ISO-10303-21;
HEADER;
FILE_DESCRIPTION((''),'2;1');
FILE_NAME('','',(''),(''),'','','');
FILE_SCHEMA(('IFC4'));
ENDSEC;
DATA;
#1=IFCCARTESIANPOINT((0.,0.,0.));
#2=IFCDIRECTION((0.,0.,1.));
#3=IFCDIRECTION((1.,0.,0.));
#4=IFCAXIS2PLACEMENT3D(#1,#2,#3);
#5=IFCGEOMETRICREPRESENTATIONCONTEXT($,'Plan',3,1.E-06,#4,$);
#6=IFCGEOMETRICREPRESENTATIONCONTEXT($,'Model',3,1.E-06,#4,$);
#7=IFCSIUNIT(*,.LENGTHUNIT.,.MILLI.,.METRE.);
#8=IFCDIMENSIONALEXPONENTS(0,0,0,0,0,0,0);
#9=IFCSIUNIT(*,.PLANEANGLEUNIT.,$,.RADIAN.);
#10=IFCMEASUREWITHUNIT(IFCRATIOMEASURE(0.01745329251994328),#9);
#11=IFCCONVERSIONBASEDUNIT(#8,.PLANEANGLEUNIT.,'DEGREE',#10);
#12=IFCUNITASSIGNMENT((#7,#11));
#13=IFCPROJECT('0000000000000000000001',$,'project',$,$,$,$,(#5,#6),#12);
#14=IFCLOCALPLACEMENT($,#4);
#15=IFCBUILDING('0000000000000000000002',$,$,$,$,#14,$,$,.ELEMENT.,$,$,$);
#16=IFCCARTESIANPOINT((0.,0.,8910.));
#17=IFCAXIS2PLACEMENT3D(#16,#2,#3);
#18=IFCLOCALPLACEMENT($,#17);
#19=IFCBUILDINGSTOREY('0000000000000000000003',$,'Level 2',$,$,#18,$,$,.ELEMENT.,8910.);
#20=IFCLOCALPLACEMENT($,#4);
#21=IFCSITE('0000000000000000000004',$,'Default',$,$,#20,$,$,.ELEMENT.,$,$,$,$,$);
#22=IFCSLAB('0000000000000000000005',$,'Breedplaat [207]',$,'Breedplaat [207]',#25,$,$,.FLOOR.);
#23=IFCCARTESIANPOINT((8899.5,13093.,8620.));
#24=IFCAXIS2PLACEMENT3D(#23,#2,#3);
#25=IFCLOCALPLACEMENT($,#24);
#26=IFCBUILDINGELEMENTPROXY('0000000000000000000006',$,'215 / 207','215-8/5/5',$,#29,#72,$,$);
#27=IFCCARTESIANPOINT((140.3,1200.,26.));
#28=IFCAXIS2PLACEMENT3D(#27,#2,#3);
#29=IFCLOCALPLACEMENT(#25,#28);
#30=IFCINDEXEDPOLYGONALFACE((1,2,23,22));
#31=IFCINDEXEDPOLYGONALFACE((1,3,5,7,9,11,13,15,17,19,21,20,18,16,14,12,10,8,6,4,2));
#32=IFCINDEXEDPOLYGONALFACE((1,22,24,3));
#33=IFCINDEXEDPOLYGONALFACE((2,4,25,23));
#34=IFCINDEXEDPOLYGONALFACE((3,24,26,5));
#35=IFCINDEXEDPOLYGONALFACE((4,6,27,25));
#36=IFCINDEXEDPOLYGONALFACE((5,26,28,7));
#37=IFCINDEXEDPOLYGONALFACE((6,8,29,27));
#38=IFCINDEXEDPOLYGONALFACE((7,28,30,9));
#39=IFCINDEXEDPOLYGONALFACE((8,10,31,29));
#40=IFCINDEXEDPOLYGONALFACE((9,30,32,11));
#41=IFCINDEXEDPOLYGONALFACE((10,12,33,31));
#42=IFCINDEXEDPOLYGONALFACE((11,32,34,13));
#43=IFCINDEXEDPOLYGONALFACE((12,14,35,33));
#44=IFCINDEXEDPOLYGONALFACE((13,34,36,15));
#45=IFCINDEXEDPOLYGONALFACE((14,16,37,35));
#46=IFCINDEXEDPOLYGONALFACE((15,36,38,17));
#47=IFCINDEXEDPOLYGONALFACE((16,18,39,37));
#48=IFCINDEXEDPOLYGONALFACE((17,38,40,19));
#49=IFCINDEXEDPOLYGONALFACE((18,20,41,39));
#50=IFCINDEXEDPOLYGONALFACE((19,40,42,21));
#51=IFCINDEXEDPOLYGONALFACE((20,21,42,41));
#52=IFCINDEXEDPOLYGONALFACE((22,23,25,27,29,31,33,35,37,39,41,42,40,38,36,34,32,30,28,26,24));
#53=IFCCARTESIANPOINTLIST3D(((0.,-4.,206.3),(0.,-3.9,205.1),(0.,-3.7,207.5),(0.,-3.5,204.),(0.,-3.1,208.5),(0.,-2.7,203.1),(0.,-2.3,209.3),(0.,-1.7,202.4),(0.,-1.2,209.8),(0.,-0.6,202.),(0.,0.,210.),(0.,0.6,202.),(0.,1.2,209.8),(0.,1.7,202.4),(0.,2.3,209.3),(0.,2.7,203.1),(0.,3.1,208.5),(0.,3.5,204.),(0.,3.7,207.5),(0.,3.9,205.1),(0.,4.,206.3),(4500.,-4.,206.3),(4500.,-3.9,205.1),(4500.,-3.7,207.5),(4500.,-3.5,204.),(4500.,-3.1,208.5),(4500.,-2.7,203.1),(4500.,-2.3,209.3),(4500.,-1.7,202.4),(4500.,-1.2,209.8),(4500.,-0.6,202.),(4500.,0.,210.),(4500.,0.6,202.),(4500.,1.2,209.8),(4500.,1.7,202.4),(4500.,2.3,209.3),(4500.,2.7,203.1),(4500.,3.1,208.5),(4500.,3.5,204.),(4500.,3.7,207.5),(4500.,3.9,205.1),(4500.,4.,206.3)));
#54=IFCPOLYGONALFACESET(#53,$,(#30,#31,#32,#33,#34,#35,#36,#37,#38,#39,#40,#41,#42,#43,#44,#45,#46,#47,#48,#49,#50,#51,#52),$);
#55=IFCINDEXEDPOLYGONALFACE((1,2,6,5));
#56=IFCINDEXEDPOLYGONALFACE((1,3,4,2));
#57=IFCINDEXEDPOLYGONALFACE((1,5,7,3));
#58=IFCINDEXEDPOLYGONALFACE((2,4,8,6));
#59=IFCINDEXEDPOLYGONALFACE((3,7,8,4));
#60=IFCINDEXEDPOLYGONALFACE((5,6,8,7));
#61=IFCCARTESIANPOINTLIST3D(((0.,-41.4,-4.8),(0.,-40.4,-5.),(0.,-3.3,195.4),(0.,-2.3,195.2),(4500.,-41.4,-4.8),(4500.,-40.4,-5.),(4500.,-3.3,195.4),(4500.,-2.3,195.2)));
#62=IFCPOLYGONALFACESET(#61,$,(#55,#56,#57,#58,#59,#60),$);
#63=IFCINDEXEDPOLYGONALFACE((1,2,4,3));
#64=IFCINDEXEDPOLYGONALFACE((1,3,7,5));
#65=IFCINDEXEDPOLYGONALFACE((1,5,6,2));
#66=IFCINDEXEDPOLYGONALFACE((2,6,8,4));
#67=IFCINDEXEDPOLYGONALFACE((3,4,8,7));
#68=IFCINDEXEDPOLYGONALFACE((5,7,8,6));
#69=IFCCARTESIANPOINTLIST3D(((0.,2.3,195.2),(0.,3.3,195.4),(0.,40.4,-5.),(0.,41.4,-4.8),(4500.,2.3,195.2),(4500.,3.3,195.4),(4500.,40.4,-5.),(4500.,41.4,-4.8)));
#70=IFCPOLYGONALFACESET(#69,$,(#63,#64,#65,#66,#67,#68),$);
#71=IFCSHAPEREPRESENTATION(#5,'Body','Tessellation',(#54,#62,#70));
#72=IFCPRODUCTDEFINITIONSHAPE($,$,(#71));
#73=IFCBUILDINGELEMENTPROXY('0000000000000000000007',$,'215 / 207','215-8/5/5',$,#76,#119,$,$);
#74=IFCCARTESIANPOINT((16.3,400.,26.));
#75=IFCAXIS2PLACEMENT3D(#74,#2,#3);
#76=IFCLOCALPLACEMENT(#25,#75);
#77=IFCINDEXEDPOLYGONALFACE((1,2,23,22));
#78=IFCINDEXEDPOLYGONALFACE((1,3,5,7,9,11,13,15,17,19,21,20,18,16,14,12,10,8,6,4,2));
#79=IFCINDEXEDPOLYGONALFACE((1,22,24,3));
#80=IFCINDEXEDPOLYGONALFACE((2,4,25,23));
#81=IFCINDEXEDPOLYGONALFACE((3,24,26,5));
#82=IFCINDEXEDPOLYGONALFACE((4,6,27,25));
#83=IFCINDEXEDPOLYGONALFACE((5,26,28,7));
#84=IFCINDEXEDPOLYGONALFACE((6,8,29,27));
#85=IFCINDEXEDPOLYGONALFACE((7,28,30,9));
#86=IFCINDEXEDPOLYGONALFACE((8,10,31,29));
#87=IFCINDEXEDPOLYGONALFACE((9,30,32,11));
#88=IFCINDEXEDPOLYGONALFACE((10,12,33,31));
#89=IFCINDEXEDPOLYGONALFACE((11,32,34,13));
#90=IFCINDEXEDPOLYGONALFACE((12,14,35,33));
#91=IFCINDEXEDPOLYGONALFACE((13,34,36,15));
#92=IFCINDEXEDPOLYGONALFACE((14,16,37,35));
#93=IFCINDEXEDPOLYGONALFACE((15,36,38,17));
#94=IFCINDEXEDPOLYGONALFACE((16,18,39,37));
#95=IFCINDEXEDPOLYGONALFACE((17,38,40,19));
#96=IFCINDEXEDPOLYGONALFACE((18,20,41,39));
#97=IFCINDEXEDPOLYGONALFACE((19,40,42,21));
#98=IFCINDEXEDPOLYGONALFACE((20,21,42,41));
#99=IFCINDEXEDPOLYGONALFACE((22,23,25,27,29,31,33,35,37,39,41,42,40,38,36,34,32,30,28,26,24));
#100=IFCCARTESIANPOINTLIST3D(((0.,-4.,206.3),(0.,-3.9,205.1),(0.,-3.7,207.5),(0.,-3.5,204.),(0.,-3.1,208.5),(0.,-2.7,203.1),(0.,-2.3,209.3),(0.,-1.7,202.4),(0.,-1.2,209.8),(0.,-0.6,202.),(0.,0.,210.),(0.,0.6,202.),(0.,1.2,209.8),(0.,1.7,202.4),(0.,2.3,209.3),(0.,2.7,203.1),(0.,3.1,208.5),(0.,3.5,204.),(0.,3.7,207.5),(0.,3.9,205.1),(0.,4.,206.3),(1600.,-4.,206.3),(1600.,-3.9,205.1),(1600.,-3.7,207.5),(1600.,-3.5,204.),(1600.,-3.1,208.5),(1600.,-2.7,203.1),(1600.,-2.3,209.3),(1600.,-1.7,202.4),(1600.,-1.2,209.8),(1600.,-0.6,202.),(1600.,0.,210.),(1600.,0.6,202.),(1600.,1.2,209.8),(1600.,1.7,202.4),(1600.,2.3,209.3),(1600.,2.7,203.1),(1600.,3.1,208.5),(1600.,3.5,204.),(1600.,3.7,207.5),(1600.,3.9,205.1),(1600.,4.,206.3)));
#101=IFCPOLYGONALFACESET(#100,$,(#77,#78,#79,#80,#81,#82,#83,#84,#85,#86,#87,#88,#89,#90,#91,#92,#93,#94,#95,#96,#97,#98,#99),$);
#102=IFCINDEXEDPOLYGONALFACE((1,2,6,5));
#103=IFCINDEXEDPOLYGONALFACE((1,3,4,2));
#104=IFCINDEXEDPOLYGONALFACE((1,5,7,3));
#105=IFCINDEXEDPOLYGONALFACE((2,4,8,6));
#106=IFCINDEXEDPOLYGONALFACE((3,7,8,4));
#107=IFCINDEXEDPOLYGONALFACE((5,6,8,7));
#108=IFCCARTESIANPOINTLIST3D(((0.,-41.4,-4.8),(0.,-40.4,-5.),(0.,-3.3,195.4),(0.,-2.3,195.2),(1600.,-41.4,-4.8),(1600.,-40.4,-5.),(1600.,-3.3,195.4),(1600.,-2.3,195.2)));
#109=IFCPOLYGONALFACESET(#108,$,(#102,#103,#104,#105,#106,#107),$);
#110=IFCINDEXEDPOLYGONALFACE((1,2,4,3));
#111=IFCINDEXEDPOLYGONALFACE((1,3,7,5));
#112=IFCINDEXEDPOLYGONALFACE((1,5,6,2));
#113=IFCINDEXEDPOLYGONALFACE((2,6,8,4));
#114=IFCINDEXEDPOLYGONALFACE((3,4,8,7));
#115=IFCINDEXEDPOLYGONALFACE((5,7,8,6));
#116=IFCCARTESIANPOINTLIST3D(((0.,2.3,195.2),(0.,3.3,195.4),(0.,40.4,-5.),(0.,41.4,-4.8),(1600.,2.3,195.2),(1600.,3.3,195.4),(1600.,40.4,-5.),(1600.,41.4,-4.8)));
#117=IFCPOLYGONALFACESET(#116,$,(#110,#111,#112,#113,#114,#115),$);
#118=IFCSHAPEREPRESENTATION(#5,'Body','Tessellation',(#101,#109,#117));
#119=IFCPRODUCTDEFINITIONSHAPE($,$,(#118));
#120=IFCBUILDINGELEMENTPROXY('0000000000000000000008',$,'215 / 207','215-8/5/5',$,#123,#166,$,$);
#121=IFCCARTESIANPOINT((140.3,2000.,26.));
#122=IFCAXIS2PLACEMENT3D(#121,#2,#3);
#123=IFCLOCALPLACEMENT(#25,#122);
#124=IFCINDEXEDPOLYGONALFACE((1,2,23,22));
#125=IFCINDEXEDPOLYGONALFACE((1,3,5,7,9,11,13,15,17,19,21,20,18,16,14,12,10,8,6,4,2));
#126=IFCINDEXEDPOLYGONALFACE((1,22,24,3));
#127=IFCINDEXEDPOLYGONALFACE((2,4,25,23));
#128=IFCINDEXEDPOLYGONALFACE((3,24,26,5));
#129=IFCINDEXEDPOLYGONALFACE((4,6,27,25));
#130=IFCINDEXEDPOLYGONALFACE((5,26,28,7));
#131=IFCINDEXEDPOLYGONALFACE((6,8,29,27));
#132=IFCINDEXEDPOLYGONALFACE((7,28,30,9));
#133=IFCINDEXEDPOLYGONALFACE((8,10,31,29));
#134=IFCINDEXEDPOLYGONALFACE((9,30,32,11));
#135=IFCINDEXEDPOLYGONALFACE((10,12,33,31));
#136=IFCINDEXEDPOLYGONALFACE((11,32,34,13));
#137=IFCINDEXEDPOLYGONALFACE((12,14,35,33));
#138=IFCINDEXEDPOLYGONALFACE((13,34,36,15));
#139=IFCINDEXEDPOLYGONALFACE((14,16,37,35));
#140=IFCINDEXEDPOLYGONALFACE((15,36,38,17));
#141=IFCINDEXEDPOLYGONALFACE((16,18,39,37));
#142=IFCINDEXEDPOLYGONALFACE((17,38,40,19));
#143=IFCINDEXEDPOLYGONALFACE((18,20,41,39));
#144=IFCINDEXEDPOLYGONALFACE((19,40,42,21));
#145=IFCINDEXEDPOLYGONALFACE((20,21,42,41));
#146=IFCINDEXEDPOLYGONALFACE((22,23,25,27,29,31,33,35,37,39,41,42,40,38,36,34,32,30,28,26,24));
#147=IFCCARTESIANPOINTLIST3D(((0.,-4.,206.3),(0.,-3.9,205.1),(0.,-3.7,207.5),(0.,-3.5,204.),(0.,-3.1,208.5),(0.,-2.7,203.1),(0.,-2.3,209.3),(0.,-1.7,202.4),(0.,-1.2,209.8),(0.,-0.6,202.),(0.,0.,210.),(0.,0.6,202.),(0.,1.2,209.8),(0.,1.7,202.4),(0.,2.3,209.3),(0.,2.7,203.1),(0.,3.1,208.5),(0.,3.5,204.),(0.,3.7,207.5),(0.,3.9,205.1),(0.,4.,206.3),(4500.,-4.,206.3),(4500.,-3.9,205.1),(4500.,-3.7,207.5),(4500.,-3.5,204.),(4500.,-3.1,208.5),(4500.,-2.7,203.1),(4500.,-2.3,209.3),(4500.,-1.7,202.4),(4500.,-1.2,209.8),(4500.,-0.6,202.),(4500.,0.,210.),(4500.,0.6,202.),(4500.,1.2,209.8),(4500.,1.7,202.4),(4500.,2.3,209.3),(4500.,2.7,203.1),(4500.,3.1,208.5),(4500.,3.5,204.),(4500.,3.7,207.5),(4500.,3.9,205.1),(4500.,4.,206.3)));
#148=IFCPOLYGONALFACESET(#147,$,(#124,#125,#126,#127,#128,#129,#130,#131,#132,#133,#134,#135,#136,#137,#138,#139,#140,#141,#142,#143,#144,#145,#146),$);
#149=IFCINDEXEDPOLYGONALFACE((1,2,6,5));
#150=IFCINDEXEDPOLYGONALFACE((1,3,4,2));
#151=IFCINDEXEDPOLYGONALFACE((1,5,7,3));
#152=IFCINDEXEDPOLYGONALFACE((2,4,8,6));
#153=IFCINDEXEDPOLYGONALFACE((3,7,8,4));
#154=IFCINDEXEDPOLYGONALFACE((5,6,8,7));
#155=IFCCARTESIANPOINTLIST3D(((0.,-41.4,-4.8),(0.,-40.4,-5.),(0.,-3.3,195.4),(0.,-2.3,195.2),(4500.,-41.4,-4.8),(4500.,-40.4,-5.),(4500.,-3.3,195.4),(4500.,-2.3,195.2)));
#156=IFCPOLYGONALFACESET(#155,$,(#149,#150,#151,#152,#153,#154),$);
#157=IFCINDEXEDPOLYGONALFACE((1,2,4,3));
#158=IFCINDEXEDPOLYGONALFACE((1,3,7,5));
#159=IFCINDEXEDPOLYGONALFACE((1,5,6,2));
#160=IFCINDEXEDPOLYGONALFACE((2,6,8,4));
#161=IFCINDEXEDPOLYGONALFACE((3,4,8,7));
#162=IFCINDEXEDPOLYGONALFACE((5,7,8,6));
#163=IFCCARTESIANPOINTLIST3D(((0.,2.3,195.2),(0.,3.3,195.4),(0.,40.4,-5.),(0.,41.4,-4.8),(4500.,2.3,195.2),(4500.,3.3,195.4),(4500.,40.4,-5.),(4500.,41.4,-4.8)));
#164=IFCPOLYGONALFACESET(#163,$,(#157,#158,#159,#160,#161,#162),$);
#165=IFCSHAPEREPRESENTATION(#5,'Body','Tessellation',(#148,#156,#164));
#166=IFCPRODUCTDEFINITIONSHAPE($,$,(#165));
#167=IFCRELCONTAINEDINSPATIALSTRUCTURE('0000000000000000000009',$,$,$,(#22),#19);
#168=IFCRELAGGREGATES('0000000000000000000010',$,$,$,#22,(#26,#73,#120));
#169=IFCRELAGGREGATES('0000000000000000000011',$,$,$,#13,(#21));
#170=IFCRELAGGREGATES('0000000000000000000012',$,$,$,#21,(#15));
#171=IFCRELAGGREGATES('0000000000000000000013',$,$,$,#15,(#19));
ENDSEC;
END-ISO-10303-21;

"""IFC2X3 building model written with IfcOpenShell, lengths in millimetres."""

from ifc_helpers import new_model, entity, si_unit, converted_unit, frame, origin_with_axes, origin_2d_with_axis, place, context, project, spatial, rectangle, circle, extrude, element, aggregate, save


model = new_model("IFC2X3")

# Units and contexts
plan_context = context("Plan", 3, precision=1e-06, world=origin_with_axes())
model_context = context("Model", 3, precision=1e-06, world=origin_with_axes())
ifc_project = project(units=[si_unit("LENGTHUNIT", "METRE", prefix="MILLI"), converted_unit("PLANEANGLEUNIT", "DEGREE", entity("IfcRatioMeasure", 0.01745329251994328), si_unit("PLANEANGLEUNIT", "RADIAN"), dimensions=[0, 0, 0, 0, 0, 0, 0])], contexts=[plan_context, model_context])

# Site, building, storey
site_placement = place(None, origin_with_axes())
site = spatial("IfcSite", under=ifc_project, at=site_placement, Name="Default", CompositionType="ELEMENT")
building_placement = place(None, origin_with_axes())
building = spatial("IfcBuilding", under=site, at=building_placement, CompositionType="ELEMENT")
storey_placement = place(None, frame((0.0, 0.0, 8910.0), z_axis=(0.0, 0.0, 1.0), x_axis=(1.0, 0.0, 0.0)))
storey = spatial("IfcBuildingStorey", under=building, at=storey_placement, Name="Level 2", CompositionType="ELEMENT", Elevation=8910.0)

# Slab, building element proxies
slab_1_placement = place(None, frame((8899.5, 13093.0, 8620.0), z_axis=(0.0, 0.0, 1.0), x_axis=(1.0, 0.0, 0.0)))
slab_1 = element("IfcSlab", 1, at=slab_1_placement, inside=storey, Name="Breedplaat [207]", ObjectType="Breedplaat [207]", PredefinedType="FLOOR")
proxy_1_placement = place(slab_1_placement, frame((140.3, 1200.0, 26.0), z_axis=(0.0, 0.0, 1.0), x_axis=(1.0, 0.0, 0.0)))
proxy_1 = element("IfcBuildingElementProxy", 2, at=proxy_1_placement, Name="215 / 207", Description="215-8/5/5", context=plan_context, shape_type="SweptSolid", body=[
    extrude(circle(Radius=4.0, at=origin_2d_with_axis()), frame((0.0, 0.0, 206.0), z_axis=(1.0, 0.0, 0.0), x_axis=(0.0, 0.0, 1.0)), (0.0, 0.0, 1.0), 4500.0),
    extrude(rectangle(XDim=203.8, YDim=1.0, at=origin_2d_with_axis()), frame((0.0, -21.9, 95.2), z_axis=(1.0, 0.0, 0.0), x_axis=(0.0, 0.187112, 0.982339)), (0.0, 0.0, 1.0), 4500.0),
    extrude(rectangle(XDim=203.8, YDim=1.0, at=origin_2d_with_axis()), frame((0.0, 21.9, 95.2), z_axis=(1.0, 0.0, 0.0), x_axis=(0.0, -0.187112, 0.982339)), (0.0, 0.0, 1.0), 4500.0),
])
proxy_2_placement = place(slab_1_placement, frame((16.3, 400.0, 26.0), z_axis=(0.0, 0.0, 1.0), x_axis=(1.0, 0.0, 0.0)))
proxy_2 = element("IfcBuildingElementProxy", 3, at=proxy_2_placement, Name="215 / 207", Description="215-8/5/5", context=plan_context, shape_type="SweptSolid", body=[
    extrude(circle(Radius=4.0, at=origin_2d_with_axis()), frame((0.0, 0.0, 206.0), z_axis=(1.0, 0.0, 0.0), x_axis=(0.0, 0.0, 1.0)), (0.0, 0.0, 1.0), 1600.0),
    extrude(rectangle(XDim=203.8, YDim=1.0, at=origin_2d_with_axis()), frame((0.0, -21.9, 95.2), z_axis=(1.0, 0.0, 0.0), x_axis=(0.0, 0.187112, 0.982339)), (0.0, 0.0, 1.0), 1600.0),
    extrude(rectangle(XDim=203.8, YDim=1.0, at=origin_2d_with_axis()), frame((0.0, 21.9, 95.2), z_axis=(1.0, 0.0, 0.0), x_axis=(0.0, -0.187112, 0.982339)), (0.0, 0.0, 1.0), 1600.0),
])
proxy_3_placement = place(slab_1_placement, frame((140.3, 2000.0, 26.0), z_axis=(0.0, 0.0, 1.0), x_axis=(1.0, 0.0, 0.0)))
proxy_3 = element("IfcBuildingElementProxy", 4, at=proxy_3_placement, Name="215 / 207", Description="215-8/5/5", context=plan_context, shape_type="SweptSolid", body=[
    extrude(circle(Radius=4.0, at=origin_2d_with_axis()), frame((0.0, 0.0, 206.0), z_axis=(1.0, 0.0, 0.0), x_axis=(0.0, 0.0, 1.0)), (0.0, 0.0, 1.0), 4500.0),
    extrude(rectangle(XDim=203.8, YDim=1.0, at=origin_2d_with_axis()), frame((0.0, -21.9, 95.2), z_axis=(1.0, 0.0, 0.0), x_axis=(0.0, 0.187112, 0.982339)), (0.0, 0.0, 1.0), 4500.0),
    extrude(rectangle(XDim=203.8, YDim=1.0, at=origin_2d_with_axis()), frame((0.0, 21.9, 95.2), z_axis=(1.0, 0.0, 0.0), x_axis=(0.0, -0.187112, 0.982339)), (0.0, 0.0, 1.0), 4500.0),
])
aggregate(slab_1, [proxy_1, proxy_2, proxy_3])

save(model, "model.ifc")
